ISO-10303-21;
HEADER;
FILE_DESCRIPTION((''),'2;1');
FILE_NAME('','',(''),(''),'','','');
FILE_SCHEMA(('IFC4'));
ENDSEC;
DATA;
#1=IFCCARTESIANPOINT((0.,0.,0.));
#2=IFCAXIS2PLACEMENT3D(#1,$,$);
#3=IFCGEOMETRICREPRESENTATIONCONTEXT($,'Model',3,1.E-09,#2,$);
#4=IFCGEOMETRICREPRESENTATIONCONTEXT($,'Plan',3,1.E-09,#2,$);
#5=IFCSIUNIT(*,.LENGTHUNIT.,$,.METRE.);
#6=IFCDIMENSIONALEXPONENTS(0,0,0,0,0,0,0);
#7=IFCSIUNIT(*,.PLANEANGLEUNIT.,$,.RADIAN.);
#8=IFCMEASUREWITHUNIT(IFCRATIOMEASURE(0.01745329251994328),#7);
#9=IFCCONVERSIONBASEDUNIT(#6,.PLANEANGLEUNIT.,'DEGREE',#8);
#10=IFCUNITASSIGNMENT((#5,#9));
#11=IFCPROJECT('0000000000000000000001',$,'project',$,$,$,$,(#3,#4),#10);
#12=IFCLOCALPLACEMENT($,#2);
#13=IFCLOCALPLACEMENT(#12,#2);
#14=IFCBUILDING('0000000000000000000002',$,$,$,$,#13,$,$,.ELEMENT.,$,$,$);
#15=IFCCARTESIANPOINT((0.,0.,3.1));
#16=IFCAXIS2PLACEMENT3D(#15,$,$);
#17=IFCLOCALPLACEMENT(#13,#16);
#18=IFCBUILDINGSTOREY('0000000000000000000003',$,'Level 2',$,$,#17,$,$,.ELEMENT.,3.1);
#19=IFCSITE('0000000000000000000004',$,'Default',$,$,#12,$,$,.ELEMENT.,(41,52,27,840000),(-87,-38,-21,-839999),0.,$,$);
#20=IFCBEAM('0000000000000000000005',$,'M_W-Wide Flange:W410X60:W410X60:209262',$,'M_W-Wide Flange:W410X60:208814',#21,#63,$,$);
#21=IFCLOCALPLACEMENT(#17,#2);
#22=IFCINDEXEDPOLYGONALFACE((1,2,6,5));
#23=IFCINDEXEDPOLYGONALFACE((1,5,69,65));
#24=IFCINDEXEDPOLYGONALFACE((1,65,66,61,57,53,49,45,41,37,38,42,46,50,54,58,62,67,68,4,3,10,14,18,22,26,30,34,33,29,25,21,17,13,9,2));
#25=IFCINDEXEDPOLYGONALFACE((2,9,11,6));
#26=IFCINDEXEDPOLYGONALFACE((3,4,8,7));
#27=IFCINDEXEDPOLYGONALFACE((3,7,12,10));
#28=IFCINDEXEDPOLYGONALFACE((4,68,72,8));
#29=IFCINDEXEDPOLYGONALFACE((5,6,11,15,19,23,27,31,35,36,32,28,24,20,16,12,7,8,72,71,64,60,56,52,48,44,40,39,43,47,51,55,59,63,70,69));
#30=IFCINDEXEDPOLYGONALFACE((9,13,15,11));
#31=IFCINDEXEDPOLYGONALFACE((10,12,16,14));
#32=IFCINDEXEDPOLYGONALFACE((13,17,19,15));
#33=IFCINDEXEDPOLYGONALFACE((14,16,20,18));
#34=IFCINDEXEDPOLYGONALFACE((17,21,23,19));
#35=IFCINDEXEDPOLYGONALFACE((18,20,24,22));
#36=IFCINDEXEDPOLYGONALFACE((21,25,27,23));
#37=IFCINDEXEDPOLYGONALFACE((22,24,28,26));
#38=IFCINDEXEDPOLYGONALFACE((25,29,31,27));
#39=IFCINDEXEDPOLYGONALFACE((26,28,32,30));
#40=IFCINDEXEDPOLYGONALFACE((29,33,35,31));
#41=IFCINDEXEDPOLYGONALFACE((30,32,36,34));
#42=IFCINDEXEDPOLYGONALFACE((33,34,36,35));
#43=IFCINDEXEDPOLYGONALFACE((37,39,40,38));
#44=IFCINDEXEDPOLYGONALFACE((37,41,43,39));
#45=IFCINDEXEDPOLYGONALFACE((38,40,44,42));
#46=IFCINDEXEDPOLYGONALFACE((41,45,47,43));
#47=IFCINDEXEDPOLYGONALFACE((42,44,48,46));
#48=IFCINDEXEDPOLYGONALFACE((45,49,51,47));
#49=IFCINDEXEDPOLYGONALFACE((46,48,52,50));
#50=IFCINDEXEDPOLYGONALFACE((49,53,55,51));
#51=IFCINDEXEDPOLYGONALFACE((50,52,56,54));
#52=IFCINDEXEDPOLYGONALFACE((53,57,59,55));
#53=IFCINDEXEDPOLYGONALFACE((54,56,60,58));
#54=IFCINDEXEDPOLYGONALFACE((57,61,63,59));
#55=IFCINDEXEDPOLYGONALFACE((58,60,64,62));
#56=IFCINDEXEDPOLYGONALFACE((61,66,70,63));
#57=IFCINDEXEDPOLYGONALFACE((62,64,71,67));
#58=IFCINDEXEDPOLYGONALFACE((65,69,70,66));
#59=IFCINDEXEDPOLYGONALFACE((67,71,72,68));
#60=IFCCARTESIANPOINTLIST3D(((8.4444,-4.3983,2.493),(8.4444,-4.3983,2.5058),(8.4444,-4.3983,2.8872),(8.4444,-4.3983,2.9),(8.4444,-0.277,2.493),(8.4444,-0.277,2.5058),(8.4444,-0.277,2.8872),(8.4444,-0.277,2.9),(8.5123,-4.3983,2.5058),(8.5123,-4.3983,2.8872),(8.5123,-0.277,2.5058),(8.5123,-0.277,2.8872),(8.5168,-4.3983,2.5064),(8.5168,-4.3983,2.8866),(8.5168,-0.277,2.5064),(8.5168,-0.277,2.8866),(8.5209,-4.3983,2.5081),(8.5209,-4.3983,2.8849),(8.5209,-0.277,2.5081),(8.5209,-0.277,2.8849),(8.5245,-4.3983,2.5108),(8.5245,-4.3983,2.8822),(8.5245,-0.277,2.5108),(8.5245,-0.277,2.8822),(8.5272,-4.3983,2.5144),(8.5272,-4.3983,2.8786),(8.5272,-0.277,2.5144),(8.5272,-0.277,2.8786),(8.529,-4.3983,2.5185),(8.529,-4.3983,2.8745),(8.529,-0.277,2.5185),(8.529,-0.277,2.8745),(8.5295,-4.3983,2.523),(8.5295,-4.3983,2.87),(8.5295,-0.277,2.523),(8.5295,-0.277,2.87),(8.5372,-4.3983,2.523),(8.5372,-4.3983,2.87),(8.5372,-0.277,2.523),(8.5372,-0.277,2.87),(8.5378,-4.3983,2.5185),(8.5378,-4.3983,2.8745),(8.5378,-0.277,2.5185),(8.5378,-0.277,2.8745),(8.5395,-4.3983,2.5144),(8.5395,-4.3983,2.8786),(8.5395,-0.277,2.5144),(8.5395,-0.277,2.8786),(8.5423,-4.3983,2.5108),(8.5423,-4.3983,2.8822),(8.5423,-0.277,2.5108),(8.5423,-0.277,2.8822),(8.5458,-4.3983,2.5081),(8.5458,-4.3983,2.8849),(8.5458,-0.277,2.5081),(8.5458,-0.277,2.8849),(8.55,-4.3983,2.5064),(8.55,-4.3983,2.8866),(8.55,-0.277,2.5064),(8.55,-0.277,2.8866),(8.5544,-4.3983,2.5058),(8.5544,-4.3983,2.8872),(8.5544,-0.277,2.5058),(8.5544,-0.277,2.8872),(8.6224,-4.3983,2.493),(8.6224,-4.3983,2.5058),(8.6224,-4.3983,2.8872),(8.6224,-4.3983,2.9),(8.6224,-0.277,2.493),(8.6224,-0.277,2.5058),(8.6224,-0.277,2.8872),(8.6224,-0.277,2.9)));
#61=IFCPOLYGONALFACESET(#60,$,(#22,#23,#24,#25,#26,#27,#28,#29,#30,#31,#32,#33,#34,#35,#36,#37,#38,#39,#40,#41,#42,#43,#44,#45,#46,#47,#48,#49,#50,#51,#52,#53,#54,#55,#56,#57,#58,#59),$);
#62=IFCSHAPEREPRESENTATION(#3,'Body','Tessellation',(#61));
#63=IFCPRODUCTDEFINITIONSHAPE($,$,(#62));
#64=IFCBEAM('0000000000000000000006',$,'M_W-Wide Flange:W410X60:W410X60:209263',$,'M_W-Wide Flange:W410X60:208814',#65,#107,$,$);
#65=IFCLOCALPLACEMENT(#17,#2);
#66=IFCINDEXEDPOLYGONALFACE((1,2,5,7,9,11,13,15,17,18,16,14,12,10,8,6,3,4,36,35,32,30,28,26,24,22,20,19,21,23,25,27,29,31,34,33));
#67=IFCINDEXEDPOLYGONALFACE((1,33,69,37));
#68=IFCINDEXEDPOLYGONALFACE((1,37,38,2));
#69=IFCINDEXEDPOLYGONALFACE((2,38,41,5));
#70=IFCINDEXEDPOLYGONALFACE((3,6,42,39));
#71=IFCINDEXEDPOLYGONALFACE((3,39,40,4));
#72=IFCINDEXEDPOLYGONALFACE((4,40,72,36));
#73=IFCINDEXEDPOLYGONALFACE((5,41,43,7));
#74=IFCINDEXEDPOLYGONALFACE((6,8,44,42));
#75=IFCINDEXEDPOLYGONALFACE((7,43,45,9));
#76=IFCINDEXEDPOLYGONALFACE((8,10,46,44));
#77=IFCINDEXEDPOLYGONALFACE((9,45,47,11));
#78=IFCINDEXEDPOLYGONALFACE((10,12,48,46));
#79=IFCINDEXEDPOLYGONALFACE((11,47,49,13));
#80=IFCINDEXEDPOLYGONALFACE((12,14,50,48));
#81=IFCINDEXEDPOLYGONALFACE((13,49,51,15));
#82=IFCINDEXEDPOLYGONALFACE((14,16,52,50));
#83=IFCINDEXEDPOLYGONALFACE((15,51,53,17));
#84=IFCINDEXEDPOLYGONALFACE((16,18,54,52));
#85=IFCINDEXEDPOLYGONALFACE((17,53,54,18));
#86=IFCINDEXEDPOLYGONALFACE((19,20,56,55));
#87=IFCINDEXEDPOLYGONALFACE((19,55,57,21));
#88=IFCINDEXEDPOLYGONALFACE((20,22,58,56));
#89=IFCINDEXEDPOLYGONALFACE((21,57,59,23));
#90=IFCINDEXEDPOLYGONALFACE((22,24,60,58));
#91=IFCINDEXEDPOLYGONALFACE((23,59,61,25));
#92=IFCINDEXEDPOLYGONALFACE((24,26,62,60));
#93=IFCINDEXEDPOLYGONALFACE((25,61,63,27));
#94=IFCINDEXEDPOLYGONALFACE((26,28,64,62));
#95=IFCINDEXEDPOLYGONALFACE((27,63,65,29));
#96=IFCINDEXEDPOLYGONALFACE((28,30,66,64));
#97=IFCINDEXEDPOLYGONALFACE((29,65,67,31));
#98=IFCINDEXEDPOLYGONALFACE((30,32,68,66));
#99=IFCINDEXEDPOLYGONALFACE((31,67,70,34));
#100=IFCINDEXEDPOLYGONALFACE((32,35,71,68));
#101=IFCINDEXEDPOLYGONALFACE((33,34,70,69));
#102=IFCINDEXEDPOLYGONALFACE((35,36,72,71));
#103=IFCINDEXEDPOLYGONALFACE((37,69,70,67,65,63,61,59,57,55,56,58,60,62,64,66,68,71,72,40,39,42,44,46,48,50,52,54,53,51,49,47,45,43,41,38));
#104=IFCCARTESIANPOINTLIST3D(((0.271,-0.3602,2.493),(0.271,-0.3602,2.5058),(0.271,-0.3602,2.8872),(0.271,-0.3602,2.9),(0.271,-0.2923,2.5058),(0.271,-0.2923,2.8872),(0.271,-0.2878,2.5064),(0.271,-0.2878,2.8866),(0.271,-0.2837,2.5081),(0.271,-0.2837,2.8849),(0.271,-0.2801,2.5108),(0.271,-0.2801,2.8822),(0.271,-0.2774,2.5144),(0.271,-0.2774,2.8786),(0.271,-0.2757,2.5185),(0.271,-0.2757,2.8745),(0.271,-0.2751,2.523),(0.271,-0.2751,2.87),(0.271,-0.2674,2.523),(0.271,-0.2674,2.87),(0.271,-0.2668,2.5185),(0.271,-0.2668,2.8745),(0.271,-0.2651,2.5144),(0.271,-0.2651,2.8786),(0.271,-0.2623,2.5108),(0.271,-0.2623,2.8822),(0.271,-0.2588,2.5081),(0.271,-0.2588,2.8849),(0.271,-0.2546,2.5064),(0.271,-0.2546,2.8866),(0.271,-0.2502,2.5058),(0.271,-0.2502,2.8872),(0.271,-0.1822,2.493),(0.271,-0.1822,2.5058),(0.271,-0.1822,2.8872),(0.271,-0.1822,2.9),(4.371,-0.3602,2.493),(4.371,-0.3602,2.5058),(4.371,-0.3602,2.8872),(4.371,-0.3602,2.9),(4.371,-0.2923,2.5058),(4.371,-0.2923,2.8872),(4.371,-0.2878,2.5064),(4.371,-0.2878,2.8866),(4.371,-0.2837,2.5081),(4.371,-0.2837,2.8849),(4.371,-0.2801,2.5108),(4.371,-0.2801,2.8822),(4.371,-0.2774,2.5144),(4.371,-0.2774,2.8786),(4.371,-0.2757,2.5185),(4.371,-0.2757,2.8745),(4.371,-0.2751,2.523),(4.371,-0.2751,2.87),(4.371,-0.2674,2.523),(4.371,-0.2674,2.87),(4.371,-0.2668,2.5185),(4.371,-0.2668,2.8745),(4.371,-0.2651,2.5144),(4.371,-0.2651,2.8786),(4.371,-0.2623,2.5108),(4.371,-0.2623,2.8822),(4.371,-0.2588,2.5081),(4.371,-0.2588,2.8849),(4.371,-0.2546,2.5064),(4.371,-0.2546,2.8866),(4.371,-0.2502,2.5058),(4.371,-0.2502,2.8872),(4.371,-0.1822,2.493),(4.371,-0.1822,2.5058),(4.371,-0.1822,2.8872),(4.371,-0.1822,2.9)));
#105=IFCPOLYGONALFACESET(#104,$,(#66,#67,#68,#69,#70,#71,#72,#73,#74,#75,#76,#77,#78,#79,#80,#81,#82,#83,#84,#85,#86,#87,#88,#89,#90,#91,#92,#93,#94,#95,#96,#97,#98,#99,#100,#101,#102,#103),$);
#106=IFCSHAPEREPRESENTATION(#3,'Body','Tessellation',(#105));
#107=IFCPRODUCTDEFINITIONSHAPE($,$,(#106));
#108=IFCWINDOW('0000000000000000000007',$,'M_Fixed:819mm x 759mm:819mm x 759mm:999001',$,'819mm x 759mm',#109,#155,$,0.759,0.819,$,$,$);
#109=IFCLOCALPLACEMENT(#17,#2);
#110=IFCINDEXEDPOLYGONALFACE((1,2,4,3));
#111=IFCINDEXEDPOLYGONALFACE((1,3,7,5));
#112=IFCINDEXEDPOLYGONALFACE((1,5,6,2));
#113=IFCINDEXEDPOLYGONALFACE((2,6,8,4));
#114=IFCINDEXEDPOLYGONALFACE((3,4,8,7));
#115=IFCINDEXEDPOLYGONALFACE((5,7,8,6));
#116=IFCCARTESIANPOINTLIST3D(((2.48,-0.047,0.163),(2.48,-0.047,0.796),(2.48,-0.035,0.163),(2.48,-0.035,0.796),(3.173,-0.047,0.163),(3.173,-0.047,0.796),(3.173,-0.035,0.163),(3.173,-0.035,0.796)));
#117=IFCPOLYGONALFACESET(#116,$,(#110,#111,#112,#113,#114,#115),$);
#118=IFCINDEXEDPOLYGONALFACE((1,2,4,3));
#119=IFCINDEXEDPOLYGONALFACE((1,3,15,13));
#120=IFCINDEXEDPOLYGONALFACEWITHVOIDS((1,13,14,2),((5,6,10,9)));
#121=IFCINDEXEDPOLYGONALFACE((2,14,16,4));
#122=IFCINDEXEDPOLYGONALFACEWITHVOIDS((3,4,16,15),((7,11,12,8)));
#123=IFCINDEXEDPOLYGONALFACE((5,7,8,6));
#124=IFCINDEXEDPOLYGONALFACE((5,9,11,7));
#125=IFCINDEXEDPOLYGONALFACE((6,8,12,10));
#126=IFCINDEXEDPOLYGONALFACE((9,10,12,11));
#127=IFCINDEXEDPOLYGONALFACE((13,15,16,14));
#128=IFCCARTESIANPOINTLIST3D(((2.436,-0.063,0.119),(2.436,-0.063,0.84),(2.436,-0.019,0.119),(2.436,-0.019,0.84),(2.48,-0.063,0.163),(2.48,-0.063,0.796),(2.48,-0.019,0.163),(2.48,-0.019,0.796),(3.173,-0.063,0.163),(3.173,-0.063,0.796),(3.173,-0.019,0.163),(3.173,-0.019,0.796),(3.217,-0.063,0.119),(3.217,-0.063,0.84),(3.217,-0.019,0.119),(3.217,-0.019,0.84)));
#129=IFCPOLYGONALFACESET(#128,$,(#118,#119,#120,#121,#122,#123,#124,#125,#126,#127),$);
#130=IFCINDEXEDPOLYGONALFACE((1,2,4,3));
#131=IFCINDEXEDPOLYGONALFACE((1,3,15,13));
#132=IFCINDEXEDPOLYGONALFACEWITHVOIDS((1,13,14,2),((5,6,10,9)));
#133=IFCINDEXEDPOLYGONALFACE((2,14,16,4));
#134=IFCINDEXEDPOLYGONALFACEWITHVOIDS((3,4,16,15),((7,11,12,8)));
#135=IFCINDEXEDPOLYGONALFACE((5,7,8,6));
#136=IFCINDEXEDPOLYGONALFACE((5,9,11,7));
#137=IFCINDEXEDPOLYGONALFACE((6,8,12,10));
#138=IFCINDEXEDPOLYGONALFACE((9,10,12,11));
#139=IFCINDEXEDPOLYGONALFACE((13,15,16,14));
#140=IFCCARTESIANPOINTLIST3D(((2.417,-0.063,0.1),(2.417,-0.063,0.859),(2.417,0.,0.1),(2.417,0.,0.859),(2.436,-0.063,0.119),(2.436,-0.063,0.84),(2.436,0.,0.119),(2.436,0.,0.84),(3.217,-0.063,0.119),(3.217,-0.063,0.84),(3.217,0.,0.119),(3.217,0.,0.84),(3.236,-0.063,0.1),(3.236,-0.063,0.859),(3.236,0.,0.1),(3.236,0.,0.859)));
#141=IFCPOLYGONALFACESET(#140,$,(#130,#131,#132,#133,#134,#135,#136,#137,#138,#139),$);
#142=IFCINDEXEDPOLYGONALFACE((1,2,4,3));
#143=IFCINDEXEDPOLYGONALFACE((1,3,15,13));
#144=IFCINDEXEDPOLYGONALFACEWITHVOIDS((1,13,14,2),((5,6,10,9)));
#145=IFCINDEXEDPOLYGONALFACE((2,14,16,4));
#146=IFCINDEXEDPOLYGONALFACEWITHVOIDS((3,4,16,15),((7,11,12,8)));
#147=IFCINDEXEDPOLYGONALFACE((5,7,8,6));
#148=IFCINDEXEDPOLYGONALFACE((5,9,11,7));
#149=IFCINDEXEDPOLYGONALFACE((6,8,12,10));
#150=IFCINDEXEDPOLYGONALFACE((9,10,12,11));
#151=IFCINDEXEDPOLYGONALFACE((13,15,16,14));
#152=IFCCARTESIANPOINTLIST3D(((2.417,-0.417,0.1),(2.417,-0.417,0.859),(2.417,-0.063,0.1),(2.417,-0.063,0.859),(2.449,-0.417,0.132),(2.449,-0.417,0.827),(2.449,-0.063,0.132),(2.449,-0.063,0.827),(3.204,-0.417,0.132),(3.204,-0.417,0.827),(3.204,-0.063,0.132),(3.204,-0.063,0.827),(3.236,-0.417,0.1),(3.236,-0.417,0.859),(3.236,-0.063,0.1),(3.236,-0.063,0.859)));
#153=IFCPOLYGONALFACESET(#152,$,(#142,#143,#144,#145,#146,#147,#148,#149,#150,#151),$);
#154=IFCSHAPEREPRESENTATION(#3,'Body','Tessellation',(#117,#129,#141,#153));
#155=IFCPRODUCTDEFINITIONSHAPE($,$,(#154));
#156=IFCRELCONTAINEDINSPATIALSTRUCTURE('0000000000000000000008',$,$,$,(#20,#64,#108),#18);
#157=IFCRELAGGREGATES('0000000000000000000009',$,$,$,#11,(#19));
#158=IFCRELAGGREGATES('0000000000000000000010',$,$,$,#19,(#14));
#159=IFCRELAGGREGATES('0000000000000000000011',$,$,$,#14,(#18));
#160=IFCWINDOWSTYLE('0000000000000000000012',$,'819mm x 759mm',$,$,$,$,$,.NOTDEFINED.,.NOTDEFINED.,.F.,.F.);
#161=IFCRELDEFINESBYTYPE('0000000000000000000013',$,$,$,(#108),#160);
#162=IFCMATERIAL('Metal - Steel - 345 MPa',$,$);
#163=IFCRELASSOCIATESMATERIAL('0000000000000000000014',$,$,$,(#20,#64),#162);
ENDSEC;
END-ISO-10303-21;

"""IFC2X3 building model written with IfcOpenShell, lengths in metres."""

from ifc_helpers import new_model, entity, si_unit, converted_unit, frame, frame_2d, origin, origin_2d_with_axis, place, context, project, spatial, polyline, circle_curve, parameter, trimmed, segment, composite_curve, rectangle, outline, extrude, source, transform, mapped, material, type_object, type_shapes, element, save


model = new_model("IFC2X3")

# Units and contexts
model_context = context("Model", 3, precision=1e-09, world=origin())
plan_context = context("Plan", 3, precision=1e-09, world=origin())
ifc_project = project(units=[si_unit("LENGTHUNIT", "METRE"), converted_unit("PLANEANGLEUNIT", "DEGREE", entity("IfcRatioMeasure", 0.01745329251994328), si_unit("PLANEANGLEUNIT", "RADIAN"), dimensions=[0, 0, 0, 0, 0, 0, 0])], contexts=[model_context, plan_context])

# Site, building, storey
site_placement = place(None, origin())
site = spatial("IfcSite", under=ifc_project, at=site_placement, Name="Default", CompositionType="ELEMENT", RefLatitude=(41, 52, 27, 840000), RefLongitude=(-87, -38, -21, -839999), RefElevation=0.0)
building_placement = place(site_placement, origin())
building = spatial("IfcBuilding", under=site, at=building_placement, CompositionType="ELEMENT")
storey_placement = place(building_placement, frame((0.0, 0.0, 3.1)))
storey = spatial("IfcBuildingStorey", under=building, at=storey_placement, Name="Level 2", CompositionType="ELEMENT", Elevation=3.1)

# Beams
ifc_material_1 = material(Name="Metal - Steel - 345 MPa")
beam_1_placement = place(storey_placement, frame((8.5334, -4.3983, 2.9)))
element("IfcBeam", 1, at=beam_1_placement, inside=storey, material=ifc_material_1, Name="M_W-Wide Flange:W410X60:W410X60:209262", ObjectType="M_W-Wide Flange:W410X60:208814", context=model_context, shape_type="SweptSolid", body=[
    extrude(outline(composite_curve([segment(polyline([(-0.089, -0.1907), (-0.089, -0.2035)]), True, "CONTINUOUS"), segment(polyline([(-0.089, -0.2035), (0.089, -0.2035)]), True, "CONTINUOUS"), segment(polyline([(0.089, -0.2035), (0.089, -0.1907)]), True, "CONTINUOUS"), segment(polyline([(0.089, -0.1907), (0.021, -0.1907)]), True, "CONTINUOUS"), segment(trimmed(circle_curve(frame_2d((0.021, -0.1735), x_axis=(0.0, -1.0)), 0.0172), [parameter(270.0)], [parameter(360.0)], True, "PARAMETER"), False, "CONTINUOUS"), segment(polyline([(0.0038, -0.1735), (0.0038, 0.1735)]), True, "CONTINUOUS"), segment(trimmed(circle_curve(frame_2d((0.021, 0.1735), x_axis=(-1.0, 0.0)), 0.0172), [parameter(270.0)], [parameter(360.0)], True, "PARAMETER"), False, "CONTINUOUS"), segment(polyline([(0.021, 0.1907), (0.089, 0.1907)]), True, "CONTINUOUS"), segment(polyline([(0.089, 0.1907), (0.089, 0.2035)]), True, "CONTINUOUS"), segment(polyline([(0.089, 0.2035), (-0.089, 0.2035)]), True, "CONTINUOUS"), segment(polyline([(-0.089, 0.2035), (-0.089, 0.1907)]), True, "CONTINUOUS"), segment(polyline([(-0.089, 0.1907), (-0.0211, 0.1907)]), True, "CONTINUOUS"), segment(trimmed(circle_curve(frame_2d((-0.0211, 0.1735), x_axis=(0.0, 1.0)), 0.0172), [parameter(270.0)], [parameter(0.0)], True, "PARAMETER"), False, "CONTINUOUS"), segment(polyline([(-0.0039, 0.1735), (-0.0039, -0.1735)]), True, "CONTINUOUS"), segment(trimmed(circle_curve(frame_2d((-0.0211, -0.1735), x_axis=(1.0, 0.0)), 0.0172), [parameter(270.0)], [parameter(0.0)], True, "PARAMETER"), False, "CONTINUOUS"), segment(polyline([(-0.0211, -0.1907), (-0.089, -0.1907)]), True, "CONTINUOUS")], self_intersect=False)), frame((0.0, 0.0, -0.2035), z_axis=(0.0, -1.0, 0.0), x_axis=(1.0, 0.0, 0.0)), (0.0, 0.0, -1.0), 4.1213),
])
beam_2_placement = place(storey_placement, frame((4.371, -0.2712, 2.9), z_axis=(0.0, 0.0, 1.0), x_axis=(0.0, 1.0, 0.0)))
element("IfcBeam", 2, at=beam_2_placement, inside=storey, material=ifc_material_1, Name="M_W-Wide Flange:W410X60:W410X60:209263", ObjectType="M_W-Wide Flange:W410X60:208814", context=model_context, shape_type="SweptSolid", body=[
    extrude(outline(composite_curve([segment(polyline([(0.1907, -0.089), (0.2035, -0.089)]), True, "CONTINUOUS"), segment(polyline([(0.2035, -0.089), (0.2035, 0.089)]), True, "CONTINUOUS"), segment(polyline([(0.2035, 0.089), (0.1907, 0.089)]), True, "CONTINUOUS"), segment(polyline([(0.1907, 0.089), (0.1907, 0.0211)]), True, "CONTINUOUS"), segment(trimmed(circle_curve(frame_2d((0.1735, 0.0211), x_axis=(1.0, 0.0)), 0.0172), [parameter(270.0)], [parameter(360.0)], True, "PARAMETER"), False, "CONTINUOUS"), segment(polyline([(0.1735, 0.0039), (-0.1735, 0.0039)]), True, "CONTINUOUS"), segment(trimmed(circle_curve(frame_2d((-0.1735, 0.0211), x_axis=(0.0, -1.0)), 0.0172), [parameter(270.0)], [parameter(360.0)], True, "PARAMETER"), False, "CONTINUOUS"), segment(polyline([(-0.1907, 0.0211), (-0.1907, 0.089)]), True, "CONTINUOUS"), segment(polyline([(-0.1907, 0.089), (-0.2035, 0.089)]), True, "CONTINUOUS"), segment(polyline([(-0.2035, 0.089), (-0.2035, -0.089)]), True, "CONTINUOUS"), segment(polyline([(-0.2035, -0.089), (-0.1907, -0.089)]), True, "CONTINUOUS"), segment(polyline([(-0.1907, -0.089), (-0.1907, -0.0211)]), True, "CONTINUOUS"), segment(trimmed(circle_curve(frame_2d((-0.1735, -0.0211), x_axis=(-1.0, 0.0)), 0.0172), [parameter(270.0)], [parameter(0.0)], True, "PARAMETER"), False, "CONTINUOUS"), segment(polyline([(-0.1735, -0.0039), (0.1735, -0.0039)]), True, "CONTINUOUS"), segment(trimmed(circle_curve(frame_2d((0.1735, -0.0211), x_axis=(0.0, 1.0)), 0.0172), [parameter(270.0)], [parameter(0.0)], True, "PARAMETER"), False, "CONTINUOUS"), segment(polyline([(0.1907, -0.0211), (0.1907, -0.089)]), True, "CONTINUOUS")], self_intersect=False)), frame((0.0, 4.1, -0.2035), z_axis=(0.0, -1.0, 0.0), x_axis=(0.0, 0.0, -1.0)), (0.0, 0.0, 1.0), 4.1),
])

# Window
window_style_1 = type_object("IfcWindowStyle", Name="819mm x 759mm", ConstructionType="NOTDEFINED", OperationType="NOTDEFINED", ParameterTakesPrecedence=False, Sizeable=False)
shared_shape_1 = source(origin(), model_context, "Body", "SweptSolid", [
    extrude(rectangle(XDim=0.012, YDim=0.693, at=origin_2d_with_axis()), frame((0.4095, 0.376, 0.063), z_axis=(0.0, 0.0, 1.0), x_axis=(0.0, -1.0, 0.0)), (0.0, 0.0, 1.0), 0.633),
    extrude(outline(polyline([(-0.3905, -0.3605), (0.3905, -0.3605), (0.3905, 0.3605), (-0.3905, 0.3605), (-0.3905, -0.3605)]), holes=[polyline([(-0.3465, -0.3165), (-0.3465, 0.3165), (0.3465, 0.3165), (0.3465, -0.3165), (-0.3465, -0.3165)])]), frame((0.4095, 0.354, 0.3795), z_axis=(0.0, 1.0, 0.0), x_axis=(1.0, 0.0, 0.0)), (0.0, 0.0, 1.0), 0.044),
    extrude(outline(polyline([(-0.4095, -0.3795), (0.4095, -0.3795), (0.4095, 0.3795), (-0.4095, 0.3795), (-0.4095, -0.3795)]), holes=[polyline([(-0.3905, -0.3605), (-0.3905, 0.3605), (0.3905, 0.3605), (0.3905, -0.3605), (-0.3905, -0.3605)])]), frame((0.4095, 0.354, 0.3795), z_axis=(0.0, 1.0, 0.0), x_axis=(1.0, 0.0, 0.0)), (0.0, 0.0, 1.0), 0.063),
    extrude(outline(polyline([(-0.4095, -0.3795), (0.4095, -0.3795), (0.4095, 0.3795), (-0.4095, 0.3795), (-0.4095, -0.3795)]), holes=[polyline([(-0.3775, -0.3475), (-0.3775, 0.3475), (0.3775, 0.3475), (0.3775, -0.3475), (-0.3775, -0.3475)])]), frame((0.4095, 0.0, 0.3795), z_axis=(0.0, 1.0, 0.0), x_axis=(1.0, 0.0, 0.0)), (0.0, 0.0, 1.0), 0.354),
])
type_shapes(window_style_1, [shared_shape_1])
window_1_placement = place(storey_placement, frame((2.417, -0.417, 0.1), z_axis=(0.0, 0.0, 1.0), x_axis=(1.0, 0.0, 0.0)))
element("IfcWindow", 3, at=window_1_placement, inside=storey, type_object=window_style_1, Name="M_Fixed:819mm x 759mm:819mm x 759mm:999001", ObjectType="819mm x 759mm", OverallHeight=0.759, OverallWidth=0.819, context=model_context, shape_type="MappedRepresentation", body=[
    mapped(shared_shape_1, transform((0.0, 0.0, 0.0), scale=1.0)),
])

save(model, "model.ifc")
